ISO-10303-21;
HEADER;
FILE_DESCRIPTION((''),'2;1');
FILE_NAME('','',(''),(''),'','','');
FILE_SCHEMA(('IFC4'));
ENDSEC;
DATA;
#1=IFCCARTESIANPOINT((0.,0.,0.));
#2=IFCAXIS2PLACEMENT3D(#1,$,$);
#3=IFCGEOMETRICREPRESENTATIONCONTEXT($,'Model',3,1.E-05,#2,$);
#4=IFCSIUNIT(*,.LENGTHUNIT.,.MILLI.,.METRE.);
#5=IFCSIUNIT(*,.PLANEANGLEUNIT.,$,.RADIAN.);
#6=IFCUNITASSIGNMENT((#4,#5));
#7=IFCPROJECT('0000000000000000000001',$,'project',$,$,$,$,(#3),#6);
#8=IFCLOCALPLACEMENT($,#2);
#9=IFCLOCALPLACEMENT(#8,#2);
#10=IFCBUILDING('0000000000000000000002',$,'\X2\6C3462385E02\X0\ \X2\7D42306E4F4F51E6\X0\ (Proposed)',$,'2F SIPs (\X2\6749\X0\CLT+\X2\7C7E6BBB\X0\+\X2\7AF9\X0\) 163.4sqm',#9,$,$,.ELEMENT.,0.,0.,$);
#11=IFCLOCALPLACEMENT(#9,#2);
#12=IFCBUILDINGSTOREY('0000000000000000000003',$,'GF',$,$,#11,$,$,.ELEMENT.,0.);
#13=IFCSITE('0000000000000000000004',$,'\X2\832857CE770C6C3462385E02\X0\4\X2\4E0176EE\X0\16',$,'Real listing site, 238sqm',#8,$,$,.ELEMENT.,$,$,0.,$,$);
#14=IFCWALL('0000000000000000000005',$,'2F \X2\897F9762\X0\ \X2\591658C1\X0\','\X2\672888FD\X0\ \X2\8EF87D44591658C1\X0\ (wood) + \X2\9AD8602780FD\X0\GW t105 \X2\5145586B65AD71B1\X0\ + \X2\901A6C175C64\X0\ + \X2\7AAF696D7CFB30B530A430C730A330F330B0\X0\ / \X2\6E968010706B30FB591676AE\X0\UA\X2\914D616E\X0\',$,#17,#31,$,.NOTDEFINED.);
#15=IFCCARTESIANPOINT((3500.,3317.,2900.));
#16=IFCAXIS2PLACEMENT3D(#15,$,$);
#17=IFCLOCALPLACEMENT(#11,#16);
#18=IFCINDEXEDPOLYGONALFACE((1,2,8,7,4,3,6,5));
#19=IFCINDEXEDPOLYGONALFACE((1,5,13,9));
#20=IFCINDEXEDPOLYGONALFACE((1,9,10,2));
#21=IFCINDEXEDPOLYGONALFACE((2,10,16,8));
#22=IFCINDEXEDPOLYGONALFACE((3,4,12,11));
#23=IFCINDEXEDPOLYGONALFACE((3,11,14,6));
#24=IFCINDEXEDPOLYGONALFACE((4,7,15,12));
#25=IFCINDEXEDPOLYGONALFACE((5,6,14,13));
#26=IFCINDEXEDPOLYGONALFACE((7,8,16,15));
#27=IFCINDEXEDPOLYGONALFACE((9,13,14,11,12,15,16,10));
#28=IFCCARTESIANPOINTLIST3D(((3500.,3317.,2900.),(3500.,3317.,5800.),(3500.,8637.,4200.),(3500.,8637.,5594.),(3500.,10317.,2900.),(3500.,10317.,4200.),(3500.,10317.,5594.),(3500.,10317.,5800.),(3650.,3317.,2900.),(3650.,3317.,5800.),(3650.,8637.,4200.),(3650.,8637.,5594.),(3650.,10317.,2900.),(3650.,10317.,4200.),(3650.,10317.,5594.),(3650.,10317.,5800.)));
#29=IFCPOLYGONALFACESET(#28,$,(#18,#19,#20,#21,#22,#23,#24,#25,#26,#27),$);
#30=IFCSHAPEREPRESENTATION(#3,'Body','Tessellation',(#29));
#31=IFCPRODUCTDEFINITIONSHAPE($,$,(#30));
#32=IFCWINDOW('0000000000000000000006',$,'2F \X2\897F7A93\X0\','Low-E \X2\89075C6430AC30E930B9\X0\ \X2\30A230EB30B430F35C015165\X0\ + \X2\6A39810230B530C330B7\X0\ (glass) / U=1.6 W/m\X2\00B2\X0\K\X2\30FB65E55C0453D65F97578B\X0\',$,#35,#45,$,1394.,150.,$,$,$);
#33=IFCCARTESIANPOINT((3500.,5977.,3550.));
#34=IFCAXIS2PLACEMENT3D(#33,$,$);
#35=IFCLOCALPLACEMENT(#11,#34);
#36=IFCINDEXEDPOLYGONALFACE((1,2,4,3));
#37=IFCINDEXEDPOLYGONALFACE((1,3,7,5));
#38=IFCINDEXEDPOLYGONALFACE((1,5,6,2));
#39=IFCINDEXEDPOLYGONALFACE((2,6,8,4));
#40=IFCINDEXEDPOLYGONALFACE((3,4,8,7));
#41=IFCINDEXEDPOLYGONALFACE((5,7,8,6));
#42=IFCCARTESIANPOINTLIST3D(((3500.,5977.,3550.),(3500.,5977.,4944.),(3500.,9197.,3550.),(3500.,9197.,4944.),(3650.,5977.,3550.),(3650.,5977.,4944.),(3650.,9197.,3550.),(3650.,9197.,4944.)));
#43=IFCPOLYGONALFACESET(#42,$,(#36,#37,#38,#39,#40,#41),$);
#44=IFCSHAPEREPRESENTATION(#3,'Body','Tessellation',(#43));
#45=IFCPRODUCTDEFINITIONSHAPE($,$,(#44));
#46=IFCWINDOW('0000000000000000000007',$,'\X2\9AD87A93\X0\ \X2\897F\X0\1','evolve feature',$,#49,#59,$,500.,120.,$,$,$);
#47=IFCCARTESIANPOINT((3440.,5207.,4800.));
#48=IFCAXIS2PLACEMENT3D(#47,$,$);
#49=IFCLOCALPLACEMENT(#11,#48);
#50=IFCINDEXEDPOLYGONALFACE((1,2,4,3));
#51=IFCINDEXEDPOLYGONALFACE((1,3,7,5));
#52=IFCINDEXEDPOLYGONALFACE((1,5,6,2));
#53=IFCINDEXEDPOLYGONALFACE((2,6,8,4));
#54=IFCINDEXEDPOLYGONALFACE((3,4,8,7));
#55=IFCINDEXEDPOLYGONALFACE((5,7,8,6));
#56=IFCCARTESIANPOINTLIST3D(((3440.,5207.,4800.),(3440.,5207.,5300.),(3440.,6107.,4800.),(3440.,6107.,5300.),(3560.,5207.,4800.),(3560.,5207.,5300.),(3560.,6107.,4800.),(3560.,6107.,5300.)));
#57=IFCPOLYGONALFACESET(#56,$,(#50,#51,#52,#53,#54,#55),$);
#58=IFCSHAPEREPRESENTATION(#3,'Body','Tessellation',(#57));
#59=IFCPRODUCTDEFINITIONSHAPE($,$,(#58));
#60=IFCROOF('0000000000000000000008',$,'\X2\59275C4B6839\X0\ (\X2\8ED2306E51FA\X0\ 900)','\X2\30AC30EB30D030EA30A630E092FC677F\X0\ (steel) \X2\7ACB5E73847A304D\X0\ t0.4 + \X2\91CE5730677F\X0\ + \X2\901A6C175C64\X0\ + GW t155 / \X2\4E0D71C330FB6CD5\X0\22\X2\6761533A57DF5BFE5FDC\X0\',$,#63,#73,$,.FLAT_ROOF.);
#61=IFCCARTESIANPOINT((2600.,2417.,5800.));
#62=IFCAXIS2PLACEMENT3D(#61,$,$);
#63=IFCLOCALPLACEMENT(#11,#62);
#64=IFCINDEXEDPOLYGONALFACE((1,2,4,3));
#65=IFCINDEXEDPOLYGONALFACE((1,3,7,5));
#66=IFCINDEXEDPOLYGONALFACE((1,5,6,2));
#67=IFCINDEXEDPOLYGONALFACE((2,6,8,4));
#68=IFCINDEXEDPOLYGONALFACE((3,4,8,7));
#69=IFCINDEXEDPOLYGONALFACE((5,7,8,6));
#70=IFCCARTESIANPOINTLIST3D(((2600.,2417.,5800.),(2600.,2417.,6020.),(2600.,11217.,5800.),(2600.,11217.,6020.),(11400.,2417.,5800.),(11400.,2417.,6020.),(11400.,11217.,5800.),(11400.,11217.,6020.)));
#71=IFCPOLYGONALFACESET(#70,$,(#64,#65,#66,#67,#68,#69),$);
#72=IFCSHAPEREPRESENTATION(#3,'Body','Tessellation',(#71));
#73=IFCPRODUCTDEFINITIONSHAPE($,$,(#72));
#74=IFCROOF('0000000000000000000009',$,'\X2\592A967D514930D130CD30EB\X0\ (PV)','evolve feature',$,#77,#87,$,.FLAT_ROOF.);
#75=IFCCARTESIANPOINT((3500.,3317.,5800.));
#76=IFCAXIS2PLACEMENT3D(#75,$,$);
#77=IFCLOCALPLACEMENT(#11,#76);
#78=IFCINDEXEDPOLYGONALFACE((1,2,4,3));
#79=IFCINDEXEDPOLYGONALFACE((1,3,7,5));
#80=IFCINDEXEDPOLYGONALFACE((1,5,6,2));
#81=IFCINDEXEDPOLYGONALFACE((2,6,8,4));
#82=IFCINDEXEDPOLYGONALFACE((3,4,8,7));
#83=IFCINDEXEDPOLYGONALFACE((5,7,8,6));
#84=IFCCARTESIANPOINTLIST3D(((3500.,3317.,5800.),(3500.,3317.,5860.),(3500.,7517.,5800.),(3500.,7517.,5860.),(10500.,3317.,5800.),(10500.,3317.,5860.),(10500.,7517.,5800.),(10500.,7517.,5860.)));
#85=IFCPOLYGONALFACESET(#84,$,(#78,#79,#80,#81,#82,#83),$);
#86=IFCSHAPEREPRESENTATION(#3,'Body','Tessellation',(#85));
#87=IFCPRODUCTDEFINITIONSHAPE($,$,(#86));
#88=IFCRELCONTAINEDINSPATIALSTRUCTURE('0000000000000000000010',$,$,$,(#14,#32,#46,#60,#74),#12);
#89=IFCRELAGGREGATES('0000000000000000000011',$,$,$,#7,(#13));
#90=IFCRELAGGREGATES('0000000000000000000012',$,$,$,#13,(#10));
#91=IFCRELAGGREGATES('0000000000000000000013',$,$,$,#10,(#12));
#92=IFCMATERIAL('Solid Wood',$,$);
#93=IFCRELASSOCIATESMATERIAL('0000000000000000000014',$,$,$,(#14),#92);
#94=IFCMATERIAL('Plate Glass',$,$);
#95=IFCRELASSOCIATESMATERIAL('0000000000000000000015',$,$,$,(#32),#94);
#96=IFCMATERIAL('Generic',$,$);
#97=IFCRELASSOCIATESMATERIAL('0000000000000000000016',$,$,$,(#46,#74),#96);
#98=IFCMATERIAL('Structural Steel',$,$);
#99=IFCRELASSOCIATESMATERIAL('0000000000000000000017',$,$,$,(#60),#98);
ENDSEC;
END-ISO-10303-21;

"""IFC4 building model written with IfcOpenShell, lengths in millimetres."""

from ifc_helpers import new_model, si_unit, frame, frame_2d, origin, place, context, project, spatial, rectangle, extrude, material, element, fill, save


model = new_model("IFC4")

# Units and contexts
model_context = context("Model", 3, precision=1e-05, world=origin())
ifc_project = project(units=[si_unit("LENGTHUNIT", "METRE", prefix="MILLI"), si_unit("PLANEANGLEUNIT", "RADIAN")], contexts=[model_context])

# Site, building, storey
site_placement = place(None, origin())
site = spatial("IfcSite", under=ifc_project, at=site_placement, Name="茨城県水戸市4丁目16", ObjectType="Real listing site, 238sqm", CompositionType="ELEMENT", RefElevation=0.0)
building_placement = place(site_placement, origin())
building = spatial("IfcBuilding", under=site, at=building_placement, Name="水戸市 終の住処 (Proposed)", ObjectType="2F SIPs (杉CLT+籾殻+竹) 163.4sqm", CompositionType="ELEMENT", ElevationOfRefHeight=0.0, ElevationOfTerrain=0.0)
storey_placement = place(building_placement, origin())
storey = spatial("IfcBuildingStorey", under=building, at=storey_placement, Name="GF", CompositionType="ELEMENT", Elevation=0.0)

# Shared definitions
ifc_material_1 = material(Name="Solid Wood")
ifc_material_2 = material(Name="Generic")

# Shared definitions
ifc_material_3 = material(Name="Plate Glass")

# Wall, openings, windows
wall_1_placement = place(storey_placement, frame((3500.0, 3317.0, 2900.0)))
wall_1 = element("IfcWall", 1, at=wall_1_placement, inside=storey, material=ifc_material_1, Name="2F 西面 外壁", Description="木製 軸組外壁 (wood) + 高性能GW t105 充填断熱 + 通気層 + 窯業系サイディング / 準耐火・外皮UA配慮", PredefinedType="NOTDEFINED", context=model_context, shape_type="SweptSolid", body=[
    extrude(rectangle(XDim=150.0, YDim=7000.0, at=frame_2d((75.0, 3500.0))), frame((3500.0, 3317.0, 2900.0)), (0.0, 0.0, 1.0), 2900.0),
])
opening_1_placement = place(storey_placement, frame((3500.0, 5977.0, 3550.0)))
opening_1 = element("IfcOpeningElement", 2, at=opening_1_placement, cuts=wall_1, PredefinedType="NOTDEFINED", context=model_context, shape_type="SweptSolid", body=[
    extrude(rectangle(XDim=150.0, YDim=3220.0, at=frame_2d((75.0, 1610.0))), frame((3500.0, 5977.0, 3550.0)), (0.0, 0.0, 1.0), 1394.0),
])
opening_2_placement = place(storey_placement, frame((3440.0, 5207.0, 4800.0)))
opening_2 = element("IfcOpeningElement", 3, at=opening_2_placement, cuts=wall_1, PredefinedType="NOTDEFINED", context=model_context, shape_type="SweptSolid", body=[
    extrude(rectangle(XDim=120.0, YDim=900.0, at=frame_2d((60.0, 450.0))), frame((3440.0, 5207.0, 4800.0)), (0.0, 0.0, 1.0), 500.0),
])
window_1_placement = place(storey_placement, frame((3500.0, 5977.0, 3550.0)))
window_1 = element("IfcWindow", 4, at=window_1_placement, inside=storey, material=ifc_material_3, Name="2F 西窓", Description="Low-E 複層ガラス アルゴン封入 + 樹脂サッシ (glass) / U=1.6 W/m²K・日射取得型", OverallHeight=1394.0, OverallWidth=150.0, context=model_context, shape_type="SweptSolid", body=[
    extrude(rectangle(XDim=150.0, YDim=3220.0, at=frame_2d((75.0, 1610.0))), frame((3500.0, 5977.0, 3550.0)), (0.0, 0.0, 1.0), 1394.0),
])
fill(opening_1, window_1)
window_2_placement = place(storey_placement, frame((3440.0, 5207.0, 4800.0)))
window_2 = element("IfcWindow", 5, at=window_2_placement, inside=storey, material=ifc_material_2, Name="高窓 西1", Description="evolve feature", OverallHeight=500.0, OverallWidth=120.0, context=model_context, shape_type="SweptSolid", body=[
    extrude(rectangle(XDim=120.0, YDim=900.0, at=frame_2d((60.0, 450.0))), frame((3440.0, 5207.0, 4800.0)), (0.0, 0.0, 1.0), 500.0),
])
fill(opening_2, window_2)

# Roofs
ifc_material_4 = material(Name="Structural Steel")
roof_1_placement = place(storey_placement, frame((2600.0, 2417.0, 5800.0)))
element("IfcRoof", 6, at=roof_1_placement, inside=storey, material=ifc_material_4, Name="大屋根 (軒の出 900)", Description="ガルバリウム鋼板 (steel) 立平葺き t0.4 + 野地板 + 通気層 + GW t155 / 不燃・法22条区域対応", PredefinedType="FLAT_ROOF", context=model_context, shape_type="SweptSolid", body=[
    extrude(rectangle(XDim=8800.0, YDim=8800.0, at=frame_2d((4400.0, 4400.0))), frame((2600.0, 2417.0, 5800.0)), (0.0, 0.0, 1.0), 220.0),
])
roof_2_placement = place(storey_placement, frame((3500.0, 3317.0, 5800.0)))
element("IfcRoof", 7, at=roof_2_placement, inside=storey, material=ifc_material_2, Name="太陽光パネル (PV)", Description="evolve feature", PredefinedType="FLAT_ROOF", context=model_context, shape_type="SweptSolid", body=[
    extrude(rectangle(XDim=7000.0, YDim=4200.0, at=frame_2d((3500.0, 2100.0))), frame((3500.0, 3317.0, 5800.0)), (0.0, 0.0, 1.0), 60.0),
])

save(model, "model.ifc")
